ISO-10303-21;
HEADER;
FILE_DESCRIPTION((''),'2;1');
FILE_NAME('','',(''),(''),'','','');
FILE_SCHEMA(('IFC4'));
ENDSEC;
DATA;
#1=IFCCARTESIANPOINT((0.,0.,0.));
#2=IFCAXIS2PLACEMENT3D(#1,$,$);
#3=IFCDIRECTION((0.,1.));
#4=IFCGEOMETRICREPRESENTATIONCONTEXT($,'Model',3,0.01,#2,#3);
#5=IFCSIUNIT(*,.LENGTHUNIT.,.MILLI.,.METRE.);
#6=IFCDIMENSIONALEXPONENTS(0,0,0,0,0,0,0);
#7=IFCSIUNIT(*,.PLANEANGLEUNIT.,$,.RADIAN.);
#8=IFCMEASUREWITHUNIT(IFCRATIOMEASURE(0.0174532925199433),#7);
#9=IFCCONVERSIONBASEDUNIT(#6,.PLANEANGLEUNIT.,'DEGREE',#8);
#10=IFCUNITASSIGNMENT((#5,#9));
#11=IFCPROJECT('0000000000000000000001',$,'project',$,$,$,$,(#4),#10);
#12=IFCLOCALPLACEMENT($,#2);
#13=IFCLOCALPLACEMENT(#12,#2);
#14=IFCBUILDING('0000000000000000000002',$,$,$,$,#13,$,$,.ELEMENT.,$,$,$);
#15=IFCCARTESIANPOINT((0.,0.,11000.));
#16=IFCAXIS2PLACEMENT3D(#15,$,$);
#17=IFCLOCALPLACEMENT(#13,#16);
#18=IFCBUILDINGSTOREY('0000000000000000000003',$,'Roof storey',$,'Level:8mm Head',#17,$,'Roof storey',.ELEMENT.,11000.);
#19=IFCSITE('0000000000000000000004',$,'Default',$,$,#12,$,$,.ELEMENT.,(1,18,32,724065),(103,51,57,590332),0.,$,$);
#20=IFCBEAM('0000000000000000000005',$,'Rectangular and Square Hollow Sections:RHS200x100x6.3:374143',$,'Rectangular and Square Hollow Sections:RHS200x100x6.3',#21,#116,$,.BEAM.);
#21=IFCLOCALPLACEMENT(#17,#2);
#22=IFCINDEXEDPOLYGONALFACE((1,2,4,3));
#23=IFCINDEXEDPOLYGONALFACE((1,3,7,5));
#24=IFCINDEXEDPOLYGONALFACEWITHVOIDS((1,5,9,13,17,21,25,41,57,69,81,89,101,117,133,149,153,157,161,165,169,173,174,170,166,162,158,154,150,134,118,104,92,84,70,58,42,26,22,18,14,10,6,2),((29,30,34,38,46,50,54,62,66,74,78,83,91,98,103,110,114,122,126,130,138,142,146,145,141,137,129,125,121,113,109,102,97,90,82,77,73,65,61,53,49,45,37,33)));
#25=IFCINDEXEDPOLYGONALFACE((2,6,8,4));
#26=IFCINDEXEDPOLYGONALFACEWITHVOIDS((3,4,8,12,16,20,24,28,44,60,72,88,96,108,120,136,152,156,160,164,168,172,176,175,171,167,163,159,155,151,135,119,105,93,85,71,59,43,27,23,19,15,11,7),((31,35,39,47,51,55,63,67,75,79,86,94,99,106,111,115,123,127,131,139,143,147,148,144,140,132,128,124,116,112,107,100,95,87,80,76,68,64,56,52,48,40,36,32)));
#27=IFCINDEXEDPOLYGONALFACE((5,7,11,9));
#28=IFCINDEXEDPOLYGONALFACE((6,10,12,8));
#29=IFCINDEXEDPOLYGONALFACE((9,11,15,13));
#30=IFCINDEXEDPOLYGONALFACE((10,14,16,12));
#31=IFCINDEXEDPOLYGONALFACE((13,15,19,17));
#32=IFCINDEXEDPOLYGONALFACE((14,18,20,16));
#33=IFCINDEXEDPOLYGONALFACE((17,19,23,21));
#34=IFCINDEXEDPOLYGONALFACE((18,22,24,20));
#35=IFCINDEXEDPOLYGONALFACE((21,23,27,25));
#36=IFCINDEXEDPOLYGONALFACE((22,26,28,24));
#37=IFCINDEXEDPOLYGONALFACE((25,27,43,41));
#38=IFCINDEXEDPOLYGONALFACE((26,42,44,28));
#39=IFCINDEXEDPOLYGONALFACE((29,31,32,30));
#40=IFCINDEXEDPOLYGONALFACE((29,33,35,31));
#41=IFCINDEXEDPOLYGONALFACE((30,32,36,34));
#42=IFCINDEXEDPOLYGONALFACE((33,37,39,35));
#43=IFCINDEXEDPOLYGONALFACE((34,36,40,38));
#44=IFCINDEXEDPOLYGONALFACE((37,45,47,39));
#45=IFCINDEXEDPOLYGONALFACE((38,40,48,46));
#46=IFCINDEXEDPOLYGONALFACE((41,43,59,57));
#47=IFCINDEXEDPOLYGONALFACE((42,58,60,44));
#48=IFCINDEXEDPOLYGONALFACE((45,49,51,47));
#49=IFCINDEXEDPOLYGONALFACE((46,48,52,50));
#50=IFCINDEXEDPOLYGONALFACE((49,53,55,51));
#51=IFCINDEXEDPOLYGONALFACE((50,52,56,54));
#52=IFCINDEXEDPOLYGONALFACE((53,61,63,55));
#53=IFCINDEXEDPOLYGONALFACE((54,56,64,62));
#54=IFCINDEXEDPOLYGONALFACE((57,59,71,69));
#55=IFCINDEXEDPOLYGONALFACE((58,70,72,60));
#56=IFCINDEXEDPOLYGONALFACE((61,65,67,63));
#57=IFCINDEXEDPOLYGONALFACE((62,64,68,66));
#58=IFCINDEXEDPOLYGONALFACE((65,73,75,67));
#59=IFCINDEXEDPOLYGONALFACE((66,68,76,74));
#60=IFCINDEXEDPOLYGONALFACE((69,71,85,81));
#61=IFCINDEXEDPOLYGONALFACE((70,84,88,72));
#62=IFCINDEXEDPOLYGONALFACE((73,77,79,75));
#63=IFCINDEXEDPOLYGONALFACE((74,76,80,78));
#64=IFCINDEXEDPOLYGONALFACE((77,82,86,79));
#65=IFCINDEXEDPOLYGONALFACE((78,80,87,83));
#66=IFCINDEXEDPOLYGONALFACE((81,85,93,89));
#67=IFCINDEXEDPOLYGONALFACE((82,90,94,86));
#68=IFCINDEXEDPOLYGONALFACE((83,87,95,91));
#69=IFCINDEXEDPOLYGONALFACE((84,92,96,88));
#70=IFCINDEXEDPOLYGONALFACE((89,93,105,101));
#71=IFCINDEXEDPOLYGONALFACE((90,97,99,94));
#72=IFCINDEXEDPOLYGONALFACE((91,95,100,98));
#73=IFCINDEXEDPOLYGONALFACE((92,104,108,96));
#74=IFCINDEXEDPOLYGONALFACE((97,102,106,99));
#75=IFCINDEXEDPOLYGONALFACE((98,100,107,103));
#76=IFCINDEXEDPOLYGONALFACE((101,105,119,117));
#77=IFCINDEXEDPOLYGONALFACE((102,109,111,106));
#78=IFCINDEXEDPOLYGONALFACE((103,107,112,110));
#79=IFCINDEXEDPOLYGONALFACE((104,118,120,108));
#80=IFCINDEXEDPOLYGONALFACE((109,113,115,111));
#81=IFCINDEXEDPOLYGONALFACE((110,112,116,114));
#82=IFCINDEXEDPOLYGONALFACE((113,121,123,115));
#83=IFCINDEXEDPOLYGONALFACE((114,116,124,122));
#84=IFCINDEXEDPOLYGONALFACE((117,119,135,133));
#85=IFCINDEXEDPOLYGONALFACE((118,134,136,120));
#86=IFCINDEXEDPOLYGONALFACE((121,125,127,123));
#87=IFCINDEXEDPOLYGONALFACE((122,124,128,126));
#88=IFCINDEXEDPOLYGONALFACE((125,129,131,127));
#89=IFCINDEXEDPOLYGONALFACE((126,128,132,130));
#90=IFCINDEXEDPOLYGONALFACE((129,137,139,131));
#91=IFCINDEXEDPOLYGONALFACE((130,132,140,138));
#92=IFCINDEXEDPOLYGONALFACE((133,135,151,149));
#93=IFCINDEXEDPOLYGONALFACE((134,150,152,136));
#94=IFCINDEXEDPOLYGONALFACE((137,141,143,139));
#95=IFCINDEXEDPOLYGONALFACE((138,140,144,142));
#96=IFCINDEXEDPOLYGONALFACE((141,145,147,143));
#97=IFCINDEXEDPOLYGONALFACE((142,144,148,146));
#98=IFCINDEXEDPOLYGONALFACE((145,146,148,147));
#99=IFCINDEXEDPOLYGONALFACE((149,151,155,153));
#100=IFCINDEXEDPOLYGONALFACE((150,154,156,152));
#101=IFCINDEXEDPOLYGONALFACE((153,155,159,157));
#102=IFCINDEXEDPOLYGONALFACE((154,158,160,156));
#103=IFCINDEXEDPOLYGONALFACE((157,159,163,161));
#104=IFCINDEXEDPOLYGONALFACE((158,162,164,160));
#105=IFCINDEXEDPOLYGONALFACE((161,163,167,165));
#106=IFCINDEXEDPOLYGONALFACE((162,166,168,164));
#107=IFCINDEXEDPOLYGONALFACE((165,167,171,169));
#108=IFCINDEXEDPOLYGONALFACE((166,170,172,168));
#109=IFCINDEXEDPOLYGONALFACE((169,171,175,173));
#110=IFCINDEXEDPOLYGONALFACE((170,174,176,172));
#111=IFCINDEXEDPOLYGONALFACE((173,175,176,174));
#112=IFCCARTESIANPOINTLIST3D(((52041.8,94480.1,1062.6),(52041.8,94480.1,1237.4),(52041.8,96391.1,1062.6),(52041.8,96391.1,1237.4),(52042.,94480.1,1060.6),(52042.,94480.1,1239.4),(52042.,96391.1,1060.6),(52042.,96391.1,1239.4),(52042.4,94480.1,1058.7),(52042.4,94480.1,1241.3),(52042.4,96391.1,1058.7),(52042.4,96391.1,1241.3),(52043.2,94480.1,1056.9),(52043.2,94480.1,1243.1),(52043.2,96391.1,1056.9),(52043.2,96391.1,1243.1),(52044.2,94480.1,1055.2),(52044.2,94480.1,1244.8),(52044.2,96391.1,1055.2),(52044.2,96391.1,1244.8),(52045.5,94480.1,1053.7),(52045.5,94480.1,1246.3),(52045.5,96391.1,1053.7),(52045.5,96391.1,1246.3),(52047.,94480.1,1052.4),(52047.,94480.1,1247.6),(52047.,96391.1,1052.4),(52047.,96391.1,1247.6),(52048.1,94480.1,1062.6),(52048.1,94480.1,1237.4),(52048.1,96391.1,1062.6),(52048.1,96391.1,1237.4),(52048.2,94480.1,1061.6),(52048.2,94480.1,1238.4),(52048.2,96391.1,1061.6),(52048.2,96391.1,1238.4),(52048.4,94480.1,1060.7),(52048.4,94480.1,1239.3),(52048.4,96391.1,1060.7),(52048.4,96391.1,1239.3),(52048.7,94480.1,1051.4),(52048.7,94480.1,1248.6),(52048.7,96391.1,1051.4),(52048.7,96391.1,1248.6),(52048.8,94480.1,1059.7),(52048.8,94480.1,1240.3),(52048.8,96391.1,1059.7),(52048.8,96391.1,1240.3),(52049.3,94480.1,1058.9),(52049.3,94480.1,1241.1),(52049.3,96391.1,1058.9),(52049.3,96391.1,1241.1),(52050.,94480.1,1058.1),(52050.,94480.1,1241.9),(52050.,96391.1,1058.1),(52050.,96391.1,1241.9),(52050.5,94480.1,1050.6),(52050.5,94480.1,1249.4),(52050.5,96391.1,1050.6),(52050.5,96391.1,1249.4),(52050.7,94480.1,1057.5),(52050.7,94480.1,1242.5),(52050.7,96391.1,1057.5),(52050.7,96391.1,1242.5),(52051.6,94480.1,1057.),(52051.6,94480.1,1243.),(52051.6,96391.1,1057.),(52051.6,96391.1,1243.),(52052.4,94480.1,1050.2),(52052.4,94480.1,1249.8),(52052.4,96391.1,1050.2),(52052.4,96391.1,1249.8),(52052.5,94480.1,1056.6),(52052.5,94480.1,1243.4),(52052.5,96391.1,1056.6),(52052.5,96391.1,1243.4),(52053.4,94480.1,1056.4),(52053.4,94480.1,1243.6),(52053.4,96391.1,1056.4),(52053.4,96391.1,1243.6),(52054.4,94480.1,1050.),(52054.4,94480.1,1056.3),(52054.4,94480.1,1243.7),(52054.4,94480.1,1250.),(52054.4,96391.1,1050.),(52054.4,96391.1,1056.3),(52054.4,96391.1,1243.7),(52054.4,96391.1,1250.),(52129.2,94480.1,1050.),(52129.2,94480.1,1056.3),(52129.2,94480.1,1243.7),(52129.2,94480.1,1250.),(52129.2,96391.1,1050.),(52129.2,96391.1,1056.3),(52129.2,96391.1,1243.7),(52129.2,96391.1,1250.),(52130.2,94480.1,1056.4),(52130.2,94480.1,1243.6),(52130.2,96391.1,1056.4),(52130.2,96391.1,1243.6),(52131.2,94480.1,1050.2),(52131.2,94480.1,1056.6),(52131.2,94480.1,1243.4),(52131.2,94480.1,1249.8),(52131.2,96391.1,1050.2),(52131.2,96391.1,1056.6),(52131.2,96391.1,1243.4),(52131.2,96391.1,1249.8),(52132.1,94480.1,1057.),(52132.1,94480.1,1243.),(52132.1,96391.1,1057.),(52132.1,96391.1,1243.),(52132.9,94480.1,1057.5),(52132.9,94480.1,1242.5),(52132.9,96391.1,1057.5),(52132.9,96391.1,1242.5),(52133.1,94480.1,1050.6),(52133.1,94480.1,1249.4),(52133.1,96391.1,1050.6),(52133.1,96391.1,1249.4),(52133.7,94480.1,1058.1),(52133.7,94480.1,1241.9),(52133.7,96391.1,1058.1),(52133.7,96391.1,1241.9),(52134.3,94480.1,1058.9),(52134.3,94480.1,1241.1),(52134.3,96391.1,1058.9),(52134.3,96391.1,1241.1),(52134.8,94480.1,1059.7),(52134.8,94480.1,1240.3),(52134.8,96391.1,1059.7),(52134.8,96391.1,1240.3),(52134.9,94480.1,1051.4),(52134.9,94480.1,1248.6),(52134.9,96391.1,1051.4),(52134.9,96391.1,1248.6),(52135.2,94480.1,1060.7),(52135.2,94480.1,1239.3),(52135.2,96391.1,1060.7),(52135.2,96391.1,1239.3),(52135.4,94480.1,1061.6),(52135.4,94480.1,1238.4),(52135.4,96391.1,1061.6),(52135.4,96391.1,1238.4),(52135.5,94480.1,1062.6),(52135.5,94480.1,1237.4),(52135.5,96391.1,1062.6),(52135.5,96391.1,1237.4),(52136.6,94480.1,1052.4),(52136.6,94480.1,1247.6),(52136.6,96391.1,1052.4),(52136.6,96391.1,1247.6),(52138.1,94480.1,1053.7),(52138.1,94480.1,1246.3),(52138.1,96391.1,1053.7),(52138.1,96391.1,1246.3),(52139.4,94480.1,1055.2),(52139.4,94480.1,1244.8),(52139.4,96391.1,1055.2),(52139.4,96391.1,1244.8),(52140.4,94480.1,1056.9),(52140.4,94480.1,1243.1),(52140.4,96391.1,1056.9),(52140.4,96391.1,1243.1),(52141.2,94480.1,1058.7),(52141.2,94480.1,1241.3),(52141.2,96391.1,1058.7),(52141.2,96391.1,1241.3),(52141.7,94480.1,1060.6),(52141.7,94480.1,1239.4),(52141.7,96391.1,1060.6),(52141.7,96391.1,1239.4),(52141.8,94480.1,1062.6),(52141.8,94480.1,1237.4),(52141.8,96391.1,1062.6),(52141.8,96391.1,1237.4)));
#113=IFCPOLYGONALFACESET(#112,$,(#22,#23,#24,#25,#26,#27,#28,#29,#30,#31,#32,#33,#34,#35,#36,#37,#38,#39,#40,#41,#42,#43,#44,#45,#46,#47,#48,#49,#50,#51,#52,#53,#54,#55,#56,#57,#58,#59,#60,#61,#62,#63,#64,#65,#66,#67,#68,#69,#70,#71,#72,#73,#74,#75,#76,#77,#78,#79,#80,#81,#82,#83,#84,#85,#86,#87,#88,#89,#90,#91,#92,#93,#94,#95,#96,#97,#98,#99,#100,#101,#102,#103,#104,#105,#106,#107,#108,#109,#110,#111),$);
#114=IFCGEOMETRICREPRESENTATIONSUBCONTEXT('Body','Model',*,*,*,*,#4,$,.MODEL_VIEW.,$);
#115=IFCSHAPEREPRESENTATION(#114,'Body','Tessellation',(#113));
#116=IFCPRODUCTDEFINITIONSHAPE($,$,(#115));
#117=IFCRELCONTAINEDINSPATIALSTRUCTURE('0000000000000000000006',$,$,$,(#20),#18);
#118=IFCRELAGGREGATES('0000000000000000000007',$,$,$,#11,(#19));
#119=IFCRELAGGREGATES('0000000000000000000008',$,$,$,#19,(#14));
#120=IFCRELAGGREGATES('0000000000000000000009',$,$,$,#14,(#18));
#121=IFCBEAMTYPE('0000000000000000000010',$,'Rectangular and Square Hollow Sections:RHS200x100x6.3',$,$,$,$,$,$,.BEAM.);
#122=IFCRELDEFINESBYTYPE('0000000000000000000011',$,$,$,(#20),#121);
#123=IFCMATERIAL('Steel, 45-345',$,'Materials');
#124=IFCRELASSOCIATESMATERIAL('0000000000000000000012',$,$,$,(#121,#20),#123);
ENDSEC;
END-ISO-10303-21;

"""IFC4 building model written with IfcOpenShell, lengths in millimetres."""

from ifc_helpers import new_model, entity, si_unit, converted_unit, direction, frame, origin, place, context, subcontext, project, spatial, indexed_curve, outline, extrude, source, transform, mapped, material, type_object, type_shapes, element, save


model = new_model("IFC4")

# Units and contexts
model_context = context("Model", 3, precision=0.01, world=origin(), true_north=direction((0.0, 1.0)))
body_context = subcontext(model_context, "Body", "Model", "MODEL_VIEW")
ifc_project = project(units=[si_unit("LENGTHUNIT", "METRE", prefix="MILLI"), converted_unit("PLANEANGLEUNIT", "DEGREE", entity("IfcRatioMeasure", 0.0174532925199433), si_unit("PLANEANGLEUNIT", "RADIAN"), dimensions=[0, 0, 0, 0, 0, 0, 0])], contexts=[model_context])

# Site, building, storey
site_placement = place(None, origin())
site = spatial("IfcSite", under=ifc_project, at=site_placement, Name="Default", CompositionType="ELEMENT", RefLatitude=(1, 18, 32, 724065), RefLongitude=(103, 51, 57, 590332), RefElevation=0.0)
building_placement = place(site_placement, origin())
building = spatial("IfcBuilding", under=site, at=building_placement, CompositionType="ELEMENT")
storey_placement = place(building_placement, frame((0.0, 0.0, 11000.0)))
storey = spatial("IfcBuildingStorey", under=building, at=storey_placement, Name="Roof storey", ObjectType="Level:8mm Head", LongName="Roof storey", CompositionType="ELEMENT", Elevation=11000.0)

# Shared definitions
ifc_material = material(Name="Steel, 45-345", Category="Materials")

# Beam
beam_type_1 = type_object("IfcBeamType", Name="Rectangular and Square Hollow Sections:RHS200x100x6.3", PredefinedType="BEAM", material=ifc_material)
shared_shape_1 = source(origin(), body_context, "Body", "SweptSolid", [
    extrude(outline(indexed_curve([(87.4, -50.0), (89.4, -49.8), (91.3, -49.4), (93.1, -48.6), (94.8, -47.6), (96.3, -46.3), (97.6, -44.8), (98.6, -43.1), (99.4, -41.3), (99.8, -39.4), (100.0, -37.4), (100.0, 37.4), (99.8, 39.4), (99.4, 41.3), (98.6, 43.1), (97.6, 44.8), (96.3, 46.3), (94.8, 47.6), (93.1, 48.6), (91.3, 49.4), (89.4, 49.8), (87.4, 50.0), (-87.4, 50.0), (-89.4, 49.8), (-91.3, 49.4), (-93.1, 48.6), (-94.8, 47.6), (-96.3, 46.3), (-97.6, 44.8), (-98.6, 43.1), (-99.4, 41.3), (-99.8, 39.4), (-100.0, 37.4), (-100.0, -37.4), (-99.8, -39.4), (-99.4, -41.3), (-98.6, -43.1), (-97.6, -44.8), (-96.3, -46.3), (-94.8, -47.6), (-93.1, -48.6), (-91.3, -49.4), (-89.4, -49.8), (-87.4, -50.0), (87.4, -50.0)], self_intersect=False), holes=[indexed_curve([(93.7, 37.4), (93.7, -37.4), (93.6, -38.4), (93.4, -39.3), (93.0, -40.3), (92.5, -41.1), (91.9, -41.9), (91.1, -42.5), (90.3, -43.0), (89.3, -43.4), (88.4, -43.6), (87.4, -43.7), (-87.4, -43.7), (-88.4, -43.6), (-89.3, -43.4), (-90.3, -43.0), (-91.1, -42.5), (-91.9, -41.9), (-92.5, -41.1), (-93.0, -40.3), (-93.4, -39.3), (-93.6, -38.4), (-93.7, -37.4), (-93.7, 37.4), (-93.6, 38.4), (-93.4, 39.3), (-93.0, 40.3), (-92.5, 41.1), (-91.9, 41.9), (-91.1, 42.5), (-90.3, 43.0), (-89.3, 43.4), (-88.4, 43.6), (-87.4, 43.7), (87.4, 43.7), (88.4, 43.6), (89.3, 43.4), (90.3, 43.0), (91.1, 42.5), (91.9, 41.9), (92.5, 41.1), (93.0, 40.3), (93.4, 39.3), (93.6, 38.4), (93.7, 37.4)], self_intersect=False)]), frame((-977.0, 0.0, 0.0), z_axis=(1.0, 0.0, 0.0), x_axis=(0.0, 0.0, 1.0)), (0.0, 0.0, 1.0), 1911.0),
])
type_shapes(beam_type_1, [shared_shape_1])
beam_1_placement = place(storey_placement, frame((52091.8, 95457.1, 1150.0), z_axis=(0.0, 0.0, 1.0), x_axis=(0.0, 1.0, 0.0)))
element("IfcBeam", 1, at=beam_1_placement, inside=storey, type_object=beam_type_1, material=ifc_material, Name="Rectangular and Square Hollow Sections:RHS200x100x6.3:374143", ObjectType="Rectangular and Square Hollow Sections:RHS200x100x6.3", PredefinedType="BEAM", context=body_context, shape_type="MappedRepresentation", body=[
    mapped(shared_shape_1, transform((0.0, 0.0, 0.0), scale=1.0)),
])

save(model, "model.ifc")
